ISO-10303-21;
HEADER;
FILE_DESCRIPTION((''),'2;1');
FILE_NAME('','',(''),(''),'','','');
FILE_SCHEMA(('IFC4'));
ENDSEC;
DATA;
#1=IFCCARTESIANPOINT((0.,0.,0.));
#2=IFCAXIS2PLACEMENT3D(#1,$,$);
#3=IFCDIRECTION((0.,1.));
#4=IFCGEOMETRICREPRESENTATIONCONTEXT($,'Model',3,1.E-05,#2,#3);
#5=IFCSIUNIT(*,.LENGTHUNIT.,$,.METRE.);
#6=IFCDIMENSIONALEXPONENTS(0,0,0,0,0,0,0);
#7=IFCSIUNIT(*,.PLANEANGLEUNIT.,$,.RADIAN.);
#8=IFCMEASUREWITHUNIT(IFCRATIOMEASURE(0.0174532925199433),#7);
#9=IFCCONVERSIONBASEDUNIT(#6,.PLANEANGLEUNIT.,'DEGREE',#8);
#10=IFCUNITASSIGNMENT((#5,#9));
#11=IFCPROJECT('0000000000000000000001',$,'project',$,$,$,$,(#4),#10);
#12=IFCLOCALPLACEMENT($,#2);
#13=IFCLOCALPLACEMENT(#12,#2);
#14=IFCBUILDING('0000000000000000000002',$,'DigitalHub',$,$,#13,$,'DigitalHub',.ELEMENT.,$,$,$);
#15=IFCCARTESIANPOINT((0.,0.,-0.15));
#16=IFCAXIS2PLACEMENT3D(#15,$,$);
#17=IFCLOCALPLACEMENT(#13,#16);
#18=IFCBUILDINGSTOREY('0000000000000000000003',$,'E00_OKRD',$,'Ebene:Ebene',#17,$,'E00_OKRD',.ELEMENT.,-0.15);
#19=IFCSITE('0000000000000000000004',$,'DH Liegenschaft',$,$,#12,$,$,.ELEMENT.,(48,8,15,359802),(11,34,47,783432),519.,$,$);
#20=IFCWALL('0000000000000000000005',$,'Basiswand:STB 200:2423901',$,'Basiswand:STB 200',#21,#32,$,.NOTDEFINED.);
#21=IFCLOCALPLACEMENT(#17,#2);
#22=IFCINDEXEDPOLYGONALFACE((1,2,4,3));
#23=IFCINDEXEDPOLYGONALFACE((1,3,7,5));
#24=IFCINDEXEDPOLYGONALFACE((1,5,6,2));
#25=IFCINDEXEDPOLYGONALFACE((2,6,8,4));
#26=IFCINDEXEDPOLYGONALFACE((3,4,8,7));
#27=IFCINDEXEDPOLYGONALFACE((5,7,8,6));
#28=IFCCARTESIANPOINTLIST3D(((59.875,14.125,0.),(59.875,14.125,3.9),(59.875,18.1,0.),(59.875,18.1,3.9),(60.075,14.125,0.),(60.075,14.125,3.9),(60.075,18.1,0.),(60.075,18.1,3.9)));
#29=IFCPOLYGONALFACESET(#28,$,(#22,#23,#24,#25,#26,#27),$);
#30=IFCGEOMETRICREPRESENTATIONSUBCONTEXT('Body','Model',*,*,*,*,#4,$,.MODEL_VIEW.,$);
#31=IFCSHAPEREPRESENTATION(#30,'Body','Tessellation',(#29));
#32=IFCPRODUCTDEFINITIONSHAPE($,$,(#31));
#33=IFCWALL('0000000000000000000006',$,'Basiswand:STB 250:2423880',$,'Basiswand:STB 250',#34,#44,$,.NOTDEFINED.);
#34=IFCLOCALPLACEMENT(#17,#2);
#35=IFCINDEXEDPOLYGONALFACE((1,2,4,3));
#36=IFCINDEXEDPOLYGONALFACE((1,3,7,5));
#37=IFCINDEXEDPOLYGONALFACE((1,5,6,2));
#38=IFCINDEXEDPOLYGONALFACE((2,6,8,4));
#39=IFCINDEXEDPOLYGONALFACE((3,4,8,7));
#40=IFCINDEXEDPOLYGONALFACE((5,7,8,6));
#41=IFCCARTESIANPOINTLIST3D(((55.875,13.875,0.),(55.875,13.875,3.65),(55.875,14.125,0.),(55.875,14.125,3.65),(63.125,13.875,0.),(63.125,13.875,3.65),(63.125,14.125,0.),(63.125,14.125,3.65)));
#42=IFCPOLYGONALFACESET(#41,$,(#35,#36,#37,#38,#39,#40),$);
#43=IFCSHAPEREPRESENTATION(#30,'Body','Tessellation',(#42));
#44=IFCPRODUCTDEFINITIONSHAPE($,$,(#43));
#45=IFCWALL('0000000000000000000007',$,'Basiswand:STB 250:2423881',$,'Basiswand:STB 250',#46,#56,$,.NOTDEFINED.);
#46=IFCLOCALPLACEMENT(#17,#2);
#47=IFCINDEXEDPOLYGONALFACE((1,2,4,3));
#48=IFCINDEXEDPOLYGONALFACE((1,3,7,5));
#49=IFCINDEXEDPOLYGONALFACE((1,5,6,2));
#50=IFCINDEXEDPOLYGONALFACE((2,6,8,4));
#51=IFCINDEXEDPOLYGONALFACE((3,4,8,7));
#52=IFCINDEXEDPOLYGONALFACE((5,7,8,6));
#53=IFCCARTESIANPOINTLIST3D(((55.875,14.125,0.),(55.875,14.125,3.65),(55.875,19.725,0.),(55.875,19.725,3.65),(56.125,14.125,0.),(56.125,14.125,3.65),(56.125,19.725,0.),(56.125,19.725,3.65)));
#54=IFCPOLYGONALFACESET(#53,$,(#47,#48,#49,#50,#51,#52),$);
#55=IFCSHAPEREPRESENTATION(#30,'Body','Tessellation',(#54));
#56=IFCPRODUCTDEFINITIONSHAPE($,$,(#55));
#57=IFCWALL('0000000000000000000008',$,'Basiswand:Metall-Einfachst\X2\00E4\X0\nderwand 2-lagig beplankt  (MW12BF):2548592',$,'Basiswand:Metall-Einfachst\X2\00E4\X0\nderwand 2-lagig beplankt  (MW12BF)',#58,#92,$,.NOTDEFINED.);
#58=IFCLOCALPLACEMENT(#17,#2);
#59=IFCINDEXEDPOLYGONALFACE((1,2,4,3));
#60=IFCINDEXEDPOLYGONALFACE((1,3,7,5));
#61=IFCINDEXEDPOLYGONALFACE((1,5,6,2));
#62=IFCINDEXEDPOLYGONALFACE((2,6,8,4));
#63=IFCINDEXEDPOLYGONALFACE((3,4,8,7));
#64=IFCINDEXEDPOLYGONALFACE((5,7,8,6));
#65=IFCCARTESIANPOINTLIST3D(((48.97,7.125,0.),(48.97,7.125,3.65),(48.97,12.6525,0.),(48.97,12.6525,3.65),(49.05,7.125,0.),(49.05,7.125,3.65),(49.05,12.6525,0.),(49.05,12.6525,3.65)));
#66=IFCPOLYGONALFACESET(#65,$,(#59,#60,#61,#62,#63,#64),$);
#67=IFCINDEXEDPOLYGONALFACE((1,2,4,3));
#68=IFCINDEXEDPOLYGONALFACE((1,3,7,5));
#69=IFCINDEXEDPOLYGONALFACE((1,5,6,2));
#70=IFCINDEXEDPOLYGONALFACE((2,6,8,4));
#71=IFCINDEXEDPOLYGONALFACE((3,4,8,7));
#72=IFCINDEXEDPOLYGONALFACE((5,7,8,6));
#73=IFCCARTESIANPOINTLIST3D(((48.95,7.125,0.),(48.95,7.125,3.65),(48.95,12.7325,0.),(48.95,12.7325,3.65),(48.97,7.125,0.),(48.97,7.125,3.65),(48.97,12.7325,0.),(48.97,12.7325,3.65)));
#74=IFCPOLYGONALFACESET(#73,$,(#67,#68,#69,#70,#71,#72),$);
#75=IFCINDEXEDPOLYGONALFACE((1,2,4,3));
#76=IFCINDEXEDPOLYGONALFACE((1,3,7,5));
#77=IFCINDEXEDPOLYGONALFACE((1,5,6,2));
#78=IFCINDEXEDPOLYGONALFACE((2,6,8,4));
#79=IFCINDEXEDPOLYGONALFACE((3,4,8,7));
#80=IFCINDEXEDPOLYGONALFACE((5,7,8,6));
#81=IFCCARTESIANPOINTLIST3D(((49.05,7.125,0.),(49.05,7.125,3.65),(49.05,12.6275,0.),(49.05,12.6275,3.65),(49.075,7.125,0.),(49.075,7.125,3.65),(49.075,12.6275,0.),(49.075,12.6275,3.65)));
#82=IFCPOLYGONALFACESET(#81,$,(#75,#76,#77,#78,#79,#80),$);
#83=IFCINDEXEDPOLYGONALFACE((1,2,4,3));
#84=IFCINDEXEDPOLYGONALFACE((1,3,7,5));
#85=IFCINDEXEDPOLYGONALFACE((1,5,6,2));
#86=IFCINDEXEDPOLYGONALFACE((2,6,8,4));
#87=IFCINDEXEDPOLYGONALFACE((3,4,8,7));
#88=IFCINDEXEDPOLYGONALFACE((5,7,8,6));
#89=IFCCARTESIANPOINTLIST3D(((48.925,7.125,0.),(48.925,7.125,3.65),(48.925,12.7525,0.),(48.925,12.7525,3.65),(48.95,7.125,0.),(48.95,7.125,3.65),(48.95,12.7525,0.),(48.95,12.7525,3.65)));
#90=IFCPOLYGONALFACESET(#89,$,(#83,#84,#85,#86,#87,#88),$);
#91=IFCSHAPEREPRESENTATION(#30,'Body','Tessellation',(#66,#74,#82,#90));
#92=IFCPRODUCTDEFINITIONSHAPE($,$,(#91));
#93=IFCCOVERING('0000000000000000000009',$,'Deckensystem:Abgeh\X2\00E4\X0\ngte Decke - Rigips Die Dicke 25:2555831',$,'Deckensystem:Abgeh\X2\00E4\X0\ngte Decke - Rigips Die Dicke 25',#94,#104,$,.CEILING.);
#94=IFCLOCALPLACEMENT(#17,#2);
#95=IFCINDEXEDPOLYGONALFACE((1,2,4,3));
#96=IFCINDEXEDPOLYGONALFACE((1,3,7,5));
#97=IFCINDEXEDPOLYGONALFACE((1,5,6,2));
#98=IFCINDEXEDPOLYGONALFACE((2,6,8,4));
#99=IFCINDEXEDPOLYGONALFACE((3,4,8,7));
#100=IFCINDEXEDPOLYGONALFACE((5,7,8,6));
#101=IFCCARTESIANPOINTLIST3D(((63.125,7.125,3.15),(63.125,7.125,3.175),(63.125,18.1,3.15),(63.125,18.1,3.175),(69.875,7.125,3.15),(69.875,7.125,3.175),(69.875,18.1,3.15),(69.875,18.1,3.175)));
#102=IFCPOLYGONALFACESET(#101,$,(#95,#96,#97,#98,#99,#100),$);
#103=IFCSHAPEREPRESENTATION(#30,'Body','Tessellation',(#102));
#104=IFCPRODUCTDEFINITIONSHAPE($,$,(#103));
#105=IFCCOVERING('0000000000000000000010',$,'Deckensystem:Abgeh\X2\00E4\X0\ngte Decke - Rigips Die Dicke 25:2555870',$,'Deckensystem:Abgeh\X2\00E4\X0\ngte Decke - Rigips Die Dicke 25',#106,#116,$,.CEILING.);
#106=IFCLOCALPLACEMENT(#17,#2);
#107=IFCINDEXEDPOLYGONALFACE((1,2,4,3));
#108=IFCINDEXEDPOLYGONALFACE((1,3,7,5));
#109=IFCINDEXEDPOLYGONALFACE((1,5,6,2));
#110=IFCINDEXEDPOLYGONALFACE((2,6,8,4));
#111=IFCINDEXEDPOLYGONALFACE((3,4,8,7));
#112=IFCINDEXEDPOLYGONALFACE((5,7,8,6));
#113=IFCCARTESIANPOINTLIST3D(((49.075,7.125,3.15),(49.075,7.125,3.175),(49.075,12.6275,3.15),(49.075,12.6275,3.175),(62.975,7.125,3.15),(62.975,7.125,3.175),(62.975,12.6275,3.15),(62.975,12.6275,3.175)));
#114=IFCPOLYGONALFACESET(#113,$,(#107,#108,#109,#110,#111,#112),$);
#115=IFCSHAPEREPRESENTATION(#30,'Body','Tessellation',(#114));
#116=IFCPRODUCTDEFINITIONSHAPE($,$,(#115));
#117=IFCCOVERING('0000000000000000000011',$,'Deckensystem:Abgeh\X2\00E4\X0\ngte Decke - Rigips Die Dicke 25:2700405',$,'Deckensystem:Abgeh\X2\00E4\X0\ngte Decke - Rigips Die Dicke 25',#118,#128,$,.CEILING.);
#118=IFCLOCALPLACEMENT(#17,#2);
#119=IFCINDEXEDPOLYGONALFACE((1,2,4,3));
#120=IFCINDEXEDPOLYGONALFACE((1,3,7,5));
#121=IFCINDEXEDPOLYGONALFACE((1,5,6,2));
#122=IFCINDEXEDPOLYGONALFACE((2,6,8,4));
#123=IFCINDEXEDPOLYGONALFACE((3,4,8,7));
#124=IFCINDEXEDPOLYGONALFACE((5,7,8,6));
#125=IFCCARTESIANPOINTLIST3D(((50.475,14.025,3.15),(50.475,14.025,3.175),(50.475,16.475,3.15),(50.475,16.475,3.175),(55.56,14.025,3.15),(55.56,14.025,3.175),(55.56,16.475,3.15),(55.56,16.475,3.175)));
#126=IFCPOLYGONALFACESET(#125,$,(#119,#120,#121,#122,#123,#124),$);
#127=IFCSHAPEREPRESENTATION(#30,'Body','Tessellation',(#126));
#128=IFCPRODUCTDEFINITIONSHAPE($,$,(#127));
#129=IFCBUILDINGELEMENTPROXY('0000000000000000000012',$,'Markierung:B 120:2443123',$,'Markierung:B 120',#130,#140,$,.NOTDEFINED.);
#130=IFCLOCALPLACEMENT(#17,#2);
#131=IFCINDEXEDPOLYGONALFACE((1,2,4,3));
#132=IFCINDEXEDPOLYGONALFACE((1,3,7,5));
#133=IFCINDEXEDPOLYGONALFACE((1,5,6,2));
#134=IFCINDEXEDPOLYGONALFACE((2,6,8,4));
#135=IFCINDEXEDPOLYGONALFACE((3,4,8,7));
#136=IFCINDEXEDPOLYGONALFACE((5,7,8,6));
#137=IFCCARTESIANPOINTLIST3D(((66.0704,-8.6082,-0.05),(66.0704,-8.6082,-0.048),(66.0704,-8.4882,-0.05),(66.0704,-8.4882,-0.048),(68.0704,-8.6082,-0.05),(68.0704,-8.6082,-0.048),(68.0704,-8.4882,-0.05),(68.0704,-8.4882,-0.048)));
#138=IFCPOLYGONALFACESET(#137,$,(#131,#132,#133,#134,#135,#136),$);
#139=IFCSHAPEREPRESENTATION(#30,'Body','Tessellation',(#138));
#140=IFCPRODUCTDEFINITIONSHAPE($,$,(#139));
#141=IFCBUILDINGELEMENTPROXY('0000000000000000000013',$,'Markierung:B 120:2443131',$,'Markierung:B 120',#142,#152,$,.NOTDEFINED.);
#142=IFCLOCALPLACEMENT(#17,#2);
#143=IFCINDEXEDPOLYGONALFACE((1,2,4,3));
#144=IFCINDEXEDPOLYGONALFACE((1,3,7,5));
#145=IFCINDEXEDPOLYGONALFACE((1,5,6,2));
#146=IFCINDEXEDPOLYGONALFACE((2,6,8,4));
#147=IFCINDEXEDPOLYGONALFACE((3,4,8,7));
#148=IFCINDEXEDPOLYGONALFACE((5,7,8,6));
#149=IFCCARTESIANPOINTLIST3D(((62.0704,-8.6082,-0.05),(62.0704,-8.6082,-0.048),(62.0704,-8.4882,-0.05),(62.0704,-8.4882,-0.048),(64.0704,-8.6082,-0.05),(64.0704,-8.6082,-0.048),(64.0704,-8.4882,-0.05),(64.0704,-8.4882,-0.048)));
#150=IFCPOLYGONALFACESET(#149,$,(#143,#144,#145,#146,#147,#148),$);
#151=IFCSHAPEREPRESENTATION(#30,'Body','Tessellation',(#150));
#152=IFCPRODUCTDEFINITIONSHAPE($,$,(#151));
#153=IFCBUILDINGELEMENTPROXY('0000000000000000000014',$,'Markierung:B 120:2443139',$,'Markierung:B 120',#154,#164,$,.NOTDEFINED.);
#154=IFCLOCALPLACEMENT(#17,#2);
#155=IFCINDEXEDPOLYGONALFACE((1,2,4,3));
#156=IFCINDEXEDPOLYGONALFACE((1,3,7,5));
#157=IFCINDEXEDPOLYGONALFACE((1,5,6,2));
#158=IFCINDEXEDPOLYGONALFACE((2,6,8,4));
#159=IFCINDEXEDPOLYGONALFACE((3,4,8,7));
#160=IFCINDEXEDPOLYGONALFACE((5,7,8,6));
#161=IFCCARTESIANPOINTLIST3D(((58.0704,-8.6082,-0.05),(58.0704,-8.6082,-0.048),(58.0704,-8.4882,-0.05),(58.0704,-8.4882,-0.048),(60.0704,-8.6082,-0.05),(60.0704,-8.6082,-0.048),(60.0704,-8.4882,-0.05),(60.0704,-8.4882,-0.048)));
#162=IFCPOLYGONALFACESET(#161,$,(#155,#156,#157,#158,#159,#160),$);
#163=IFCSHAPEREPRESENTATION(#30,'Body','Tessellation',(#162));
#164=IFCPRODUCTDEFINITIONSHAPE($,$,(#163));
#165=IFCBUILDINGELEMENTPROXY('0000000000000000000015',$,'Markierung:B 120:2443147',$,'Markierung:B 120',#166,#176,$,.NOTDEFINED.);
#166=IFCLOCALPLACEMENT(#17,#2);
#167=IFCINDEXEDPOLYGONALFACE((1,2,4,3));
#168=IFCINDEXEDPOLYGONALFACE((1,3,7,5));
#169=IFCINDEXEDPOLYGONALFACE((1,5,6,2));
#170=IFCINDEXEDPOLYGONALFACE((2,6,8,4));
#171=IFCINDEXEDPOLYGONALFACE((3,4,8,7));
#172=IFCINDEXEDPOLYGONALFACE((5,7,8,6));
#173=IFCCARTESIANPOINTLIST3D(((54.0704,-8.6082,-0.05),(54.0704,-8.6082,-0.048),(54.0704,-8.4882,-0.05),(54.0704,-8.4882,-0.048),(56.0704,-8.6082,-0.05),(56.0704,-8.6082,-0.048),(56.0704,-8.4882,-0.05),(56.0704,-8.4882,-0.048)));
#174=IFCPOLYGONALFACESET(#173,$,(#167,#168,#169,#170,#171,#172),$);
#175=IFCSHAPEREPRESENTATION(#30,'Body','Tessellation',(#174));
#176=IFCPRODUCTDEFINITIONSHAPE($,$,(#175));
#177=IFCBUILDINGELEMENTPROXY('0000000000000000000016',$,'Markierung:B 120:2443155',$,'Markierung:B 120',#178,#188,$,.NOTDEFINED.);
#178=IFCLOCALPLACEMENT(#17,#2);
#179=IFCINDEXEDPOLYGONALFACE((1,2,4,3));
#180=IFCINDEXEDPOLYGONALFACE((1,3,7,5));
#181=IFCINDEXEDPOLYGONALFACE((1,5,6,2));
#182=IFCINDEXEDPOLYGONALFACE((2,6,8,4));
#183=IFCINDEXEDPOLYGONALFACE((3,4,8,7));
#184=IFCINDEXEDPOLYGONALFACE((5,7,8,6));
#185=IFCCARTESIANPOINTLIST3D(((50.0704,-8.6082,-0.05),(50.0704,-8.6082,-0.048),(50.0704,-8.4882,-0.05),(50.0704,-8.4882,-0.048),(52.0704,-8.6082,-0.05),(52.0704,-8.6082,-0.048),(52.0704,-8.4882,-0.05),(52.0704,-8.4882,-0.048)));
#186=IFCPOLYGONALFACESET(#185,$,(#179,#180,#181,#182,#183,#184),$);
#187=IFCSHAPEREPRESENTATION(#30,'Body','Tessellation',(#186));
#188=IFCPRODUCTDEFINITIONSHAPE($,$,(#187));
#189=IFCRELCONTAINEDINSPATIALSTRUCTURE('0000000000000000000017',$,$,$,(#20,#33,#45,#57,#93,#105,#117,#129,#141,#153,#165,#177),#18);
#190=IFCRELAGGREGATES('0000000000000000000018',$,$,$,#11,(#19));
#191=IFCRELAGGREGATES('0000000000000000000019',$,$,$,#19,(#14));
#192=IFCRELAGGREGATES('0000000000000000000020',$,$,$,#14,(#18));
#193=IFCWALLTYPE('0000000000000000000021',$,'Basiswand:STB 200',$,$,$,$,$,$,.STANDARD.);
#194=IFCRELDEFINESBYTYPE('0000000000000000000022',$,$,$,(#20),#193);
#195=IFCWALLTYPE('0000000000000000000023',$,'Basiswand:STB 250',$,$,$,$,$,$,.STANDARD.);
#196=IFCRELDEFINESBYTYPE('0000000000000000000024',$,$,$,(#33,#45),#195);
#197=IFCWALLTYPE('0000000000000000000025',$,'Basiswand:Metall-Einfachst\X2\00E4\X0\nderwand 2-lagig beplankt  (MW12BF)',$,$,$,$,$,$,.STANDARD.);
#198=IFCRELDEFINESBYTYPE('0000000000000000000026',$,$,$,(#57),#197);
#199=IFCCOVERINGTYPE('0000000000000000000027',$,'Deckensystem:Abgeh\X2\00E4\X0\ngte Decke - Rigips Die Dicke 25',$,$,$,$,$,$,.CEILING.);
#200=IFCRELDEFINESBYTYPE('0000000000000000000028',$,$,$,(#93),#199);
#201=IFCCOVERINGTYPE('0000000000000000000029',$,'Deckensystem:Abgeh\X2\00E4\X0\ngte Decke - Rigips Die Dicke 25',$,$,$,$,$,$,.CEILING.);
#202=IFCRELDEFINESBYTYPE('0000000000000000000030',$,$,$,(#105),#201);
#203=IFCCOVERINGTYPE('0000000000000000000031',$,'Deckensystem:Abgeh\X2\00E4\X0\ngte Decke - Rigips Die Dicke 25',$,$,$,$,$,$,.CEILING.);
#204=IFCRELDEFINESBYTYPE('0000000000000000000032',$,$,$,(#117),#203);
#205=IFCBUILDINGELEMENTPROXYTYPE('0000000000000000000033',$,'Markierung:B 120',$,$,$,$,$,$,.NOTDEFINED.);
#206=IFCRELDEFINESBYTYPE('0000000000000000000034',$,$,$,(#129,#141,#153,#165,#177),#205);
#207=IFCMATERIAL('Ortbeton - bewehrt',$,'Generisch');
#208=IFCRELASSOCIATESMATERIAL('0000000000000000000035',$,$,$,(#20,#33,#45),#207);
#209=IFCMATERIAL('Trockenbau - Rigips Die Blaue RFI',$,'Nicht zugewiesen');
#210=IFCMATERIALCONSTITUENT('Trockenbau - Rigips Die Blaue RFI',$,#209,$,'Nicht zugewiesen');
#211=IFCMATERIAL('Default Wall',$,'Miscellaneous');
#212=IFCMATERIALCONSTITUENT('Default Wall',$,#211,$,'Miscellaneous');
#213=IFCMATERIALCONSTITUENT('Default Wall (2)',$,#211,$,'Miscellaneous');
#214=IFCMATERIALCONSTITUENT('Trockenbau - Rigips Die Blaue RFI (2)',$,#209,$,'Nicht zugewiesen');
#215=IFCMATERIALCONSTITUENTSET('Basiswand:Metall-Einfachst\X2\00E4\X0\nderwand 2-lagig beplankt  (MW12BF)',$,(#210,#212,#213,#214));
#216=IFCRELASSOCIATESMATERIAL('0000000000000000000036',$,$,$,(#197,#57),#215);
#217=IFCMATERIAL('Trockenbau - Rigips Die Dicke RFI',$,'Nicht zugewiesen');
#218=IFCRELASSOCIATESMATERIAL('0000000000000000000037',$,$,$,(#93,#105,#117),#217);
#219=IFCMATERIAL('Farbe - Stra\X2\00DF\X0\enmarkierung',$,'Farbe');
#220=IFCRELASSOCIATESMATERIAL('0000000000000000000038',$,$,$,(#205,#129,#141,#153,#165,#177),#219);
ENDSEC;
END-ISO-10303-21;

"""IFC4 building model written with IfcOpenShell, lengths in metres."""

from ifc_helpers import new_model, entity, si_unit, converted_unit, direction, frame, origin, place, context, subcontext, project, spatial, indexed_curve, outline, extrude, source, transform, mapped, material, constituent, constituent_set, type_object, type_shapes, element, save


model = new_model("IFC4")

# Units and contexts
model_context = context("Model", 3, precision=1e-05, world=origin(), true_north=direction((0.0, 1.0)))
body_context = subcontext(model_context, "Body", "Model", "MODEL_VIEW")
ifc_project = project(units=[si_unit("LENGTHUNIT", "METRE"), converted_unit("PLANEANGLEUNIT", "DEGREE", entity("IfcRatioMeasure", 0.0174532925199433), si_unit("PLANEANGLEUNIT", "RADIAN"), dimensions=[0, 0, 0, 0, 0, 0, 0])], contexts=[model_context])

# Site, building, storey
site_placement = place(None, frame((0.0, 0.0, 0.0)))
site = spatial("IfcSite", under=ifc_project, at=site_placement, Name="DH Liegenschaft", CompositionType="ELEMENT", RefLatitude=(48, 8, 15, 359802), RefLongitude=(11, 34, 47, 783432), RefElevation=519.0)
building_placement = place(site_placement, origin())
building = spatial("IfcBuilding", under=site, at=building_placement, Name="DigitalHub", LongName="DigitalHub", CompositionType="ELEMENT")
storey_placement = place(building_placement, frame((0.0, 0.0, -0.15)))
storey = spatial("IfcBuildingStorey", under=building, at=storey_placement, Name="E00_OKRD", ObjectType="Ebene:Ebene", LongName="E00_OKRD", CompositionType="ELEMENT", Elevation=-0.15)

# Walls
ifc_material_1 = material(Name="Ortbeton - bewehrt", Category="Generisch")
wall_type_1 = type_object("IfcWallType", Name="Basiswand:STB 200", PredefinedType="STANDARD")
wall_1_placement = place(storey_placement, frame((59.975, 14.125, 0.0), z_axis=(0.0, 0.0, 1.0), x_axis=(0.0, 1.0, 0.0)))
element("IfcWall", 1, at=wall_1_placement, inside=storey, type_object=wall_type_1, material=ifc_material_1, Name="Basiswand:STB 200:2423901", ObjectType="Basiswand:STB 200", PredefinedType="NOTDEFINED", context=body_context, shape_type="SweptSolid", body=[
    extrude(outline(indexed_curve([(3.975, 0.1), (0.0, 0.1), (0.0, -0.1), (3.975, -0.1), (3.975, 0.1)], self_intersect=False)), origin(), (0.0, 0.0, 1.0), 3.9),
])
wall_type_2 = type_object("IfcWallType", Name="Basiswand:STB 250", PredefinedType="STANDARD")
wall_2_placement = place(storey_placement, frame((63.125, 14.0, 0.0), z_axis=(0.0, 0.0, 1.0), x_axis=(-1.0, 0.0, 0.0)))
element("IfcWall", 2, at=wall_2_placement, inside=storey, type_object=wall_type_2, material=ifc_material_1, Name="Basiswand:STB 250:2423880", ObjectType="Basiswand:STB 250", PredefinedType="NOTDEFINED", context=body_context, shape_type="SweptSolid", body=[
    extrude(outline(indexed_curve([(7.25, 0.125), (0.0, 0.125), (0.0, -0.125), (7.25, -0.125), (7.25, 0.125)], self_intersect=False)), origin(), (0.0, 0.0, 1.0), 3.65),
])
wall_3_placement = place(storey_placement, frame((56.0, 14.125, 0.0), z_axis=(0.0, 0.0, 1.0), x_axis=(0.0, 1.0, 0.0)))
element("IfcWall", 3, at=wall_3_placement, inside=storey, type_object=wall_type_2, material=ifc_material_1, Name="Basiswand:STB 250:2423881", ObjectType="Basiswand:STB 250", PredefinedType="NOTDEFINED", context=body_context, shape_type="SweptSolid", body=[
    extrude(outline(indexed_curve([(5.6, 0.125), (0.0, 0.125), (0.0, -0.125), (5.6, -0.125), (5.6, 0.125)], self_intersect=False)), origin(), (0.0, 0.0, 1.0), 3.65),
])

# Shared definitions
ifc_material_2 = material(Name="Trockenbau - Rigips Die Blaue RFI", Category="Nicht zugewiesen")
ifc_constituent_1 = constituent(ifc_material_2, Name="Trockenbau - Rigips Die Blaue RFI", Category="Nicht zugewiesen")
ifc_material_3 = material(Name="Default Wall", Category="Miscellaneous")
ifc_constituent_2 = constituent(ifc_material_3, Name="Default Wall", Category="Miscellaneous")
ifc_constituent_3 = constituent(ifc_material_3, Name="Default Wall (2)", Category="Miscellaneous")
ifc_constituent_4 = constituent(ifc_material_2, Name="Trockenbau - Rigips Die Blaue RFI (2)", Category="Nicht zugewiesen")
ifc_constituent_set_1 = constituent_set(constituents=[ifc_constituent_1, ifc_constituent_2, ifc_constituent_3, ifc_constituent_4], Name="Basiswand:Metall-Einfachständerwand 2-lagig beplankt  (MW12BF)")
wall_type_3 = type_object("IfcWallType", Name="Basiswand:Metall-Einfachständerwand 2-lagig beplankt  (MW12BF)", PredefinedType="STANDARD", material=ifc_constituent_set_1)

# Wall
wall_4_placement = place(storey_placement, frame((49.0, 12.6275, 0.0), z_axis=(0.0, 0.0, 1.0), x_axis=(0.0, -1.0, 0.0)))
element("IfcWall", 4, at=wall_4_placement, inside=storey, type_object=wall_type_3, material=ifc_constituent_set_1, Name="Basiswand:Metall-Einfachständerwand 2-lagig beplankt  (MW12BF):2548592", ObjectType="Basiswand:Metall-Einfachständerwand 2-lagig beplankt  (MW12BF)", PredefinedType="NOTDEFINED", context=body_context, shape_type="SweptSolid", body=[
    extrude(outline(indexed_curve([(-2.7637, -0.04), (2.7637, -0.04), (2.7637, 0.04), (-2.7637, 0.04), (-2.7637, -0.04)], self_intersect=False)), frame((2.7387, 0.01, 0.0)), (0.0, 0.0, 1.0), 3.65),
    extrude(outline(indexed_curve([(-2.8037, -0.01), (2.8037, -0.01), (2.8037, 0.01), (-2.8037, 0.01), (-2.8037, -0.01)], self_intersect=False)), frame((2.6987, -0.04, 0.0)), (0.0, 0.0, 1.0), 3.65),
    extrude(outline(indexed_curve([(-0.0125, -2.7512), (0.0125, -2.7512), (0.0125, 2.7512), (-0.0125, 2.7512), (-0.0125, -2.7512)], self_intersect=False)), frame((2.7512, 0.0625, 0.0), z_axis=(0.0, 0.0, 1.0), x_axis=(0.0, -1.0, 0.0)), (0.0, 0.0, 1.0), 3.65),
    extrude(outline(indexed_curve([(-0.0125, -2.8137), (0.0125, -2.8137), (0.0125, 2.8137), (-0.0125, 2.8137), (-0.0125, -2.8137)], self_intersect=False)), frame((2.6887, -0.0625, 0.0), z_axis=(0.0, 0.0, 1.0), x_axis=(0.0, 1.0, 0.0)), (0.0, 0.0, 1.0), 3.65),
])

# Coverings
ifc_material_4 = material(Name="Trockenbau - Rigips Die Dicke RFI", Category="Nicht zugewiesen")
covering_type_1 = type_object("IfcCoveringType", Name="Deckensystem:Abgehängte Decke - Rigips Die Dicke 25", PredefinedType="CEILING")
covering_1_placement = place(storey_placement, frame((63.125, 7.125, 3.15)))
element("IfcCovering", 5, at=covering_1_placement, inside=storey, type_object=covering_type_1, material=ifc_material_4, Name="Deckensystem:Abgehängte Decke - Rigips Die Dicke 25:2555831", ObjectType="Deckensystem:Abgehängte Decke - Rigips Die Dicke 25", PredefinedType="CEILING", context=body_context, shape_type="SweptSolid", body=[
    extrude(outline(indexed_curve([(-3.375, -5.4875), (3.375, -5.4875), (3.375, 5.4875), (-3.375, 5.4875), (-3.375, -5.4875)], self_intersect=False)), frame((3.375, 5.4875, 0.0), z_axis=(0.0, 0.0, 1.0), x_axis=(-1.0, 0.0, 0.0)), (0.0, 0.0, 1.0), 0.025),
])
covering_type_2 = type_object("IfcCoveringType", Name="Deckensystem:Abgehängte Decke - Rigips Die Dicke 25", PredefinedType="CEILING")
covering_2_placement = place(storey_placement, frame((49.075, 7.125, 3.15)))
element("IfcCovering", 6, at=covering_2_placement, inside=storey, type_object=covering_type_2, material=ifc_material_4, Name="Deckensystem:Abgehängte Decke - Rigips Die Dicke 25:2555870", ObjectType="Deckensystem:Abgehängte Decke - Rigips Die Dicke 25", PredefinedType="CEILING", context=body_context, shape_type="SweptSolid", body=[
    extrude(outline(indexed_curve([(-6.95, -2.7512), (6.95, -2.7512), (6.95, 2.7512), (-6.95, 2.7512), (-6.95, -2.7512)], self_intersect=False)), frame((6.95, 2.7512, 0.0), z_axis=(0.0, 0.0, 1.0), x_axis=(-1.0, 0.0, 0.0)), (0.0, 0.0, 1.0), 0.025),
])
covering_type_3 = type_object("IfcCoveringType", Name="Deckensystem:Abgehängte Decke - Rigips Die Dicke 25", PredefinedType="CEILING")
covering_3_placement = place(storey_placement, frame((50.475, 14.025, 3.15)))
element("IfcCovering", 7, at=covering_3_placement, inside=storey, type_object=covering_type_3, material=ifc_material_4, Name="Deckensystem:Abgehängte Decke - Rigips Die Dicke 25:2700405", ObjectType="Deckensystem:Abgehängte Decke - Rigips Die Dicke 25", PredefinedType="CEILING", context=body_context, shape_type="SweptSolid", body=[
    extrude(outline(indexed_curve([(-2.5425, -1.225), (2.5425, -1.225), (2.5425, 1.225), (-2.5425, 1.225), (-2.5425, -1.225)], self_intersect=False)), frame((2.5425, 1.225, 0.0), z_axis=(0.0, 0.0, 1.0), x_axis=(-1.0, 0.0, 0.0)), (0.0, 0.0, 1.0), 0.025),
])

# Building element proxies
ifc_material_5 = material(Name="Farbe - Straßenmarkierung", Category="Farbe")
building_element_proxy_type_1 = type_object("IfcBuildingElementProxyType", Name="Markierung:B 120", PredefinedType="NOTDEFINED", material=ifc_material_5)
shared_shape_1 = source(origin(), body_context, "Body", "SweptSolid", [
    extrude(outline(indexed_curve([(-0.06, -1.0), (0.06, -1.0), (0.06, 1.0), (-0.06, 1.0), (-0.06, -1.0)], self_intersect=False)), frame((0.06, 1.0, 0.0), z_axis=(0.0, 0.0, 1.0), x_axis=(-1.0, 0.0, 0.0)), (0.0, 0.0, 1.0), 0.002),
])
type_shapes(building_element_proxy_type_1, [shared_shape_1])
for number, where, z_axis, x_axis, name in (
    (8, (68.0704, -8.6082, -0.05), (0.0, 0.0, 1.0), (0.0, 1.0, 0.0), "Markierung:B 120:2443123"),
    (9, (64.0704, -8.6082, -0.05), (0.0, 0.0, 1.0), (0.0, 1.0, 0.0), "Markierung:B 120:2443131"),
    (10, (60.0704, -8.6082, -0.05), (0.0, 0.0, 1.0), (0.0, 1.0, 0.0), "Markierung:B 120:2443139"),
    (11, (56.0704, -8.6082, -0.05), (0.0, 0.0, 1.0), (0.0, 1.0, 0.0), "Markierung:B 120:2443147"),
    (12, (52.0704, -8.6082, -0.05), (0.0, 0.0, 1.0), (0.0, 1.0, 0.0), "Markierung:B 120:2443155"),
):
    element("IfcBuildingElementProxy", number, at=place(storey_placement, frame(where, z_axis=z_axis, x_axis=x_axis)), inside=storey, type_object=building_element_proxy_type_1, material=ifc_material_5, Name=name, ObjectType="Markierung:B 120", PredefinedType="NOTDEFINED", context=body_context, shape_type="MappedRepresentation", body=[
        mapped(shared_shape_1, transform((0.0, 0.0, 0.0), scale=1.0)),
    ])

save(model, "model.ifc")
